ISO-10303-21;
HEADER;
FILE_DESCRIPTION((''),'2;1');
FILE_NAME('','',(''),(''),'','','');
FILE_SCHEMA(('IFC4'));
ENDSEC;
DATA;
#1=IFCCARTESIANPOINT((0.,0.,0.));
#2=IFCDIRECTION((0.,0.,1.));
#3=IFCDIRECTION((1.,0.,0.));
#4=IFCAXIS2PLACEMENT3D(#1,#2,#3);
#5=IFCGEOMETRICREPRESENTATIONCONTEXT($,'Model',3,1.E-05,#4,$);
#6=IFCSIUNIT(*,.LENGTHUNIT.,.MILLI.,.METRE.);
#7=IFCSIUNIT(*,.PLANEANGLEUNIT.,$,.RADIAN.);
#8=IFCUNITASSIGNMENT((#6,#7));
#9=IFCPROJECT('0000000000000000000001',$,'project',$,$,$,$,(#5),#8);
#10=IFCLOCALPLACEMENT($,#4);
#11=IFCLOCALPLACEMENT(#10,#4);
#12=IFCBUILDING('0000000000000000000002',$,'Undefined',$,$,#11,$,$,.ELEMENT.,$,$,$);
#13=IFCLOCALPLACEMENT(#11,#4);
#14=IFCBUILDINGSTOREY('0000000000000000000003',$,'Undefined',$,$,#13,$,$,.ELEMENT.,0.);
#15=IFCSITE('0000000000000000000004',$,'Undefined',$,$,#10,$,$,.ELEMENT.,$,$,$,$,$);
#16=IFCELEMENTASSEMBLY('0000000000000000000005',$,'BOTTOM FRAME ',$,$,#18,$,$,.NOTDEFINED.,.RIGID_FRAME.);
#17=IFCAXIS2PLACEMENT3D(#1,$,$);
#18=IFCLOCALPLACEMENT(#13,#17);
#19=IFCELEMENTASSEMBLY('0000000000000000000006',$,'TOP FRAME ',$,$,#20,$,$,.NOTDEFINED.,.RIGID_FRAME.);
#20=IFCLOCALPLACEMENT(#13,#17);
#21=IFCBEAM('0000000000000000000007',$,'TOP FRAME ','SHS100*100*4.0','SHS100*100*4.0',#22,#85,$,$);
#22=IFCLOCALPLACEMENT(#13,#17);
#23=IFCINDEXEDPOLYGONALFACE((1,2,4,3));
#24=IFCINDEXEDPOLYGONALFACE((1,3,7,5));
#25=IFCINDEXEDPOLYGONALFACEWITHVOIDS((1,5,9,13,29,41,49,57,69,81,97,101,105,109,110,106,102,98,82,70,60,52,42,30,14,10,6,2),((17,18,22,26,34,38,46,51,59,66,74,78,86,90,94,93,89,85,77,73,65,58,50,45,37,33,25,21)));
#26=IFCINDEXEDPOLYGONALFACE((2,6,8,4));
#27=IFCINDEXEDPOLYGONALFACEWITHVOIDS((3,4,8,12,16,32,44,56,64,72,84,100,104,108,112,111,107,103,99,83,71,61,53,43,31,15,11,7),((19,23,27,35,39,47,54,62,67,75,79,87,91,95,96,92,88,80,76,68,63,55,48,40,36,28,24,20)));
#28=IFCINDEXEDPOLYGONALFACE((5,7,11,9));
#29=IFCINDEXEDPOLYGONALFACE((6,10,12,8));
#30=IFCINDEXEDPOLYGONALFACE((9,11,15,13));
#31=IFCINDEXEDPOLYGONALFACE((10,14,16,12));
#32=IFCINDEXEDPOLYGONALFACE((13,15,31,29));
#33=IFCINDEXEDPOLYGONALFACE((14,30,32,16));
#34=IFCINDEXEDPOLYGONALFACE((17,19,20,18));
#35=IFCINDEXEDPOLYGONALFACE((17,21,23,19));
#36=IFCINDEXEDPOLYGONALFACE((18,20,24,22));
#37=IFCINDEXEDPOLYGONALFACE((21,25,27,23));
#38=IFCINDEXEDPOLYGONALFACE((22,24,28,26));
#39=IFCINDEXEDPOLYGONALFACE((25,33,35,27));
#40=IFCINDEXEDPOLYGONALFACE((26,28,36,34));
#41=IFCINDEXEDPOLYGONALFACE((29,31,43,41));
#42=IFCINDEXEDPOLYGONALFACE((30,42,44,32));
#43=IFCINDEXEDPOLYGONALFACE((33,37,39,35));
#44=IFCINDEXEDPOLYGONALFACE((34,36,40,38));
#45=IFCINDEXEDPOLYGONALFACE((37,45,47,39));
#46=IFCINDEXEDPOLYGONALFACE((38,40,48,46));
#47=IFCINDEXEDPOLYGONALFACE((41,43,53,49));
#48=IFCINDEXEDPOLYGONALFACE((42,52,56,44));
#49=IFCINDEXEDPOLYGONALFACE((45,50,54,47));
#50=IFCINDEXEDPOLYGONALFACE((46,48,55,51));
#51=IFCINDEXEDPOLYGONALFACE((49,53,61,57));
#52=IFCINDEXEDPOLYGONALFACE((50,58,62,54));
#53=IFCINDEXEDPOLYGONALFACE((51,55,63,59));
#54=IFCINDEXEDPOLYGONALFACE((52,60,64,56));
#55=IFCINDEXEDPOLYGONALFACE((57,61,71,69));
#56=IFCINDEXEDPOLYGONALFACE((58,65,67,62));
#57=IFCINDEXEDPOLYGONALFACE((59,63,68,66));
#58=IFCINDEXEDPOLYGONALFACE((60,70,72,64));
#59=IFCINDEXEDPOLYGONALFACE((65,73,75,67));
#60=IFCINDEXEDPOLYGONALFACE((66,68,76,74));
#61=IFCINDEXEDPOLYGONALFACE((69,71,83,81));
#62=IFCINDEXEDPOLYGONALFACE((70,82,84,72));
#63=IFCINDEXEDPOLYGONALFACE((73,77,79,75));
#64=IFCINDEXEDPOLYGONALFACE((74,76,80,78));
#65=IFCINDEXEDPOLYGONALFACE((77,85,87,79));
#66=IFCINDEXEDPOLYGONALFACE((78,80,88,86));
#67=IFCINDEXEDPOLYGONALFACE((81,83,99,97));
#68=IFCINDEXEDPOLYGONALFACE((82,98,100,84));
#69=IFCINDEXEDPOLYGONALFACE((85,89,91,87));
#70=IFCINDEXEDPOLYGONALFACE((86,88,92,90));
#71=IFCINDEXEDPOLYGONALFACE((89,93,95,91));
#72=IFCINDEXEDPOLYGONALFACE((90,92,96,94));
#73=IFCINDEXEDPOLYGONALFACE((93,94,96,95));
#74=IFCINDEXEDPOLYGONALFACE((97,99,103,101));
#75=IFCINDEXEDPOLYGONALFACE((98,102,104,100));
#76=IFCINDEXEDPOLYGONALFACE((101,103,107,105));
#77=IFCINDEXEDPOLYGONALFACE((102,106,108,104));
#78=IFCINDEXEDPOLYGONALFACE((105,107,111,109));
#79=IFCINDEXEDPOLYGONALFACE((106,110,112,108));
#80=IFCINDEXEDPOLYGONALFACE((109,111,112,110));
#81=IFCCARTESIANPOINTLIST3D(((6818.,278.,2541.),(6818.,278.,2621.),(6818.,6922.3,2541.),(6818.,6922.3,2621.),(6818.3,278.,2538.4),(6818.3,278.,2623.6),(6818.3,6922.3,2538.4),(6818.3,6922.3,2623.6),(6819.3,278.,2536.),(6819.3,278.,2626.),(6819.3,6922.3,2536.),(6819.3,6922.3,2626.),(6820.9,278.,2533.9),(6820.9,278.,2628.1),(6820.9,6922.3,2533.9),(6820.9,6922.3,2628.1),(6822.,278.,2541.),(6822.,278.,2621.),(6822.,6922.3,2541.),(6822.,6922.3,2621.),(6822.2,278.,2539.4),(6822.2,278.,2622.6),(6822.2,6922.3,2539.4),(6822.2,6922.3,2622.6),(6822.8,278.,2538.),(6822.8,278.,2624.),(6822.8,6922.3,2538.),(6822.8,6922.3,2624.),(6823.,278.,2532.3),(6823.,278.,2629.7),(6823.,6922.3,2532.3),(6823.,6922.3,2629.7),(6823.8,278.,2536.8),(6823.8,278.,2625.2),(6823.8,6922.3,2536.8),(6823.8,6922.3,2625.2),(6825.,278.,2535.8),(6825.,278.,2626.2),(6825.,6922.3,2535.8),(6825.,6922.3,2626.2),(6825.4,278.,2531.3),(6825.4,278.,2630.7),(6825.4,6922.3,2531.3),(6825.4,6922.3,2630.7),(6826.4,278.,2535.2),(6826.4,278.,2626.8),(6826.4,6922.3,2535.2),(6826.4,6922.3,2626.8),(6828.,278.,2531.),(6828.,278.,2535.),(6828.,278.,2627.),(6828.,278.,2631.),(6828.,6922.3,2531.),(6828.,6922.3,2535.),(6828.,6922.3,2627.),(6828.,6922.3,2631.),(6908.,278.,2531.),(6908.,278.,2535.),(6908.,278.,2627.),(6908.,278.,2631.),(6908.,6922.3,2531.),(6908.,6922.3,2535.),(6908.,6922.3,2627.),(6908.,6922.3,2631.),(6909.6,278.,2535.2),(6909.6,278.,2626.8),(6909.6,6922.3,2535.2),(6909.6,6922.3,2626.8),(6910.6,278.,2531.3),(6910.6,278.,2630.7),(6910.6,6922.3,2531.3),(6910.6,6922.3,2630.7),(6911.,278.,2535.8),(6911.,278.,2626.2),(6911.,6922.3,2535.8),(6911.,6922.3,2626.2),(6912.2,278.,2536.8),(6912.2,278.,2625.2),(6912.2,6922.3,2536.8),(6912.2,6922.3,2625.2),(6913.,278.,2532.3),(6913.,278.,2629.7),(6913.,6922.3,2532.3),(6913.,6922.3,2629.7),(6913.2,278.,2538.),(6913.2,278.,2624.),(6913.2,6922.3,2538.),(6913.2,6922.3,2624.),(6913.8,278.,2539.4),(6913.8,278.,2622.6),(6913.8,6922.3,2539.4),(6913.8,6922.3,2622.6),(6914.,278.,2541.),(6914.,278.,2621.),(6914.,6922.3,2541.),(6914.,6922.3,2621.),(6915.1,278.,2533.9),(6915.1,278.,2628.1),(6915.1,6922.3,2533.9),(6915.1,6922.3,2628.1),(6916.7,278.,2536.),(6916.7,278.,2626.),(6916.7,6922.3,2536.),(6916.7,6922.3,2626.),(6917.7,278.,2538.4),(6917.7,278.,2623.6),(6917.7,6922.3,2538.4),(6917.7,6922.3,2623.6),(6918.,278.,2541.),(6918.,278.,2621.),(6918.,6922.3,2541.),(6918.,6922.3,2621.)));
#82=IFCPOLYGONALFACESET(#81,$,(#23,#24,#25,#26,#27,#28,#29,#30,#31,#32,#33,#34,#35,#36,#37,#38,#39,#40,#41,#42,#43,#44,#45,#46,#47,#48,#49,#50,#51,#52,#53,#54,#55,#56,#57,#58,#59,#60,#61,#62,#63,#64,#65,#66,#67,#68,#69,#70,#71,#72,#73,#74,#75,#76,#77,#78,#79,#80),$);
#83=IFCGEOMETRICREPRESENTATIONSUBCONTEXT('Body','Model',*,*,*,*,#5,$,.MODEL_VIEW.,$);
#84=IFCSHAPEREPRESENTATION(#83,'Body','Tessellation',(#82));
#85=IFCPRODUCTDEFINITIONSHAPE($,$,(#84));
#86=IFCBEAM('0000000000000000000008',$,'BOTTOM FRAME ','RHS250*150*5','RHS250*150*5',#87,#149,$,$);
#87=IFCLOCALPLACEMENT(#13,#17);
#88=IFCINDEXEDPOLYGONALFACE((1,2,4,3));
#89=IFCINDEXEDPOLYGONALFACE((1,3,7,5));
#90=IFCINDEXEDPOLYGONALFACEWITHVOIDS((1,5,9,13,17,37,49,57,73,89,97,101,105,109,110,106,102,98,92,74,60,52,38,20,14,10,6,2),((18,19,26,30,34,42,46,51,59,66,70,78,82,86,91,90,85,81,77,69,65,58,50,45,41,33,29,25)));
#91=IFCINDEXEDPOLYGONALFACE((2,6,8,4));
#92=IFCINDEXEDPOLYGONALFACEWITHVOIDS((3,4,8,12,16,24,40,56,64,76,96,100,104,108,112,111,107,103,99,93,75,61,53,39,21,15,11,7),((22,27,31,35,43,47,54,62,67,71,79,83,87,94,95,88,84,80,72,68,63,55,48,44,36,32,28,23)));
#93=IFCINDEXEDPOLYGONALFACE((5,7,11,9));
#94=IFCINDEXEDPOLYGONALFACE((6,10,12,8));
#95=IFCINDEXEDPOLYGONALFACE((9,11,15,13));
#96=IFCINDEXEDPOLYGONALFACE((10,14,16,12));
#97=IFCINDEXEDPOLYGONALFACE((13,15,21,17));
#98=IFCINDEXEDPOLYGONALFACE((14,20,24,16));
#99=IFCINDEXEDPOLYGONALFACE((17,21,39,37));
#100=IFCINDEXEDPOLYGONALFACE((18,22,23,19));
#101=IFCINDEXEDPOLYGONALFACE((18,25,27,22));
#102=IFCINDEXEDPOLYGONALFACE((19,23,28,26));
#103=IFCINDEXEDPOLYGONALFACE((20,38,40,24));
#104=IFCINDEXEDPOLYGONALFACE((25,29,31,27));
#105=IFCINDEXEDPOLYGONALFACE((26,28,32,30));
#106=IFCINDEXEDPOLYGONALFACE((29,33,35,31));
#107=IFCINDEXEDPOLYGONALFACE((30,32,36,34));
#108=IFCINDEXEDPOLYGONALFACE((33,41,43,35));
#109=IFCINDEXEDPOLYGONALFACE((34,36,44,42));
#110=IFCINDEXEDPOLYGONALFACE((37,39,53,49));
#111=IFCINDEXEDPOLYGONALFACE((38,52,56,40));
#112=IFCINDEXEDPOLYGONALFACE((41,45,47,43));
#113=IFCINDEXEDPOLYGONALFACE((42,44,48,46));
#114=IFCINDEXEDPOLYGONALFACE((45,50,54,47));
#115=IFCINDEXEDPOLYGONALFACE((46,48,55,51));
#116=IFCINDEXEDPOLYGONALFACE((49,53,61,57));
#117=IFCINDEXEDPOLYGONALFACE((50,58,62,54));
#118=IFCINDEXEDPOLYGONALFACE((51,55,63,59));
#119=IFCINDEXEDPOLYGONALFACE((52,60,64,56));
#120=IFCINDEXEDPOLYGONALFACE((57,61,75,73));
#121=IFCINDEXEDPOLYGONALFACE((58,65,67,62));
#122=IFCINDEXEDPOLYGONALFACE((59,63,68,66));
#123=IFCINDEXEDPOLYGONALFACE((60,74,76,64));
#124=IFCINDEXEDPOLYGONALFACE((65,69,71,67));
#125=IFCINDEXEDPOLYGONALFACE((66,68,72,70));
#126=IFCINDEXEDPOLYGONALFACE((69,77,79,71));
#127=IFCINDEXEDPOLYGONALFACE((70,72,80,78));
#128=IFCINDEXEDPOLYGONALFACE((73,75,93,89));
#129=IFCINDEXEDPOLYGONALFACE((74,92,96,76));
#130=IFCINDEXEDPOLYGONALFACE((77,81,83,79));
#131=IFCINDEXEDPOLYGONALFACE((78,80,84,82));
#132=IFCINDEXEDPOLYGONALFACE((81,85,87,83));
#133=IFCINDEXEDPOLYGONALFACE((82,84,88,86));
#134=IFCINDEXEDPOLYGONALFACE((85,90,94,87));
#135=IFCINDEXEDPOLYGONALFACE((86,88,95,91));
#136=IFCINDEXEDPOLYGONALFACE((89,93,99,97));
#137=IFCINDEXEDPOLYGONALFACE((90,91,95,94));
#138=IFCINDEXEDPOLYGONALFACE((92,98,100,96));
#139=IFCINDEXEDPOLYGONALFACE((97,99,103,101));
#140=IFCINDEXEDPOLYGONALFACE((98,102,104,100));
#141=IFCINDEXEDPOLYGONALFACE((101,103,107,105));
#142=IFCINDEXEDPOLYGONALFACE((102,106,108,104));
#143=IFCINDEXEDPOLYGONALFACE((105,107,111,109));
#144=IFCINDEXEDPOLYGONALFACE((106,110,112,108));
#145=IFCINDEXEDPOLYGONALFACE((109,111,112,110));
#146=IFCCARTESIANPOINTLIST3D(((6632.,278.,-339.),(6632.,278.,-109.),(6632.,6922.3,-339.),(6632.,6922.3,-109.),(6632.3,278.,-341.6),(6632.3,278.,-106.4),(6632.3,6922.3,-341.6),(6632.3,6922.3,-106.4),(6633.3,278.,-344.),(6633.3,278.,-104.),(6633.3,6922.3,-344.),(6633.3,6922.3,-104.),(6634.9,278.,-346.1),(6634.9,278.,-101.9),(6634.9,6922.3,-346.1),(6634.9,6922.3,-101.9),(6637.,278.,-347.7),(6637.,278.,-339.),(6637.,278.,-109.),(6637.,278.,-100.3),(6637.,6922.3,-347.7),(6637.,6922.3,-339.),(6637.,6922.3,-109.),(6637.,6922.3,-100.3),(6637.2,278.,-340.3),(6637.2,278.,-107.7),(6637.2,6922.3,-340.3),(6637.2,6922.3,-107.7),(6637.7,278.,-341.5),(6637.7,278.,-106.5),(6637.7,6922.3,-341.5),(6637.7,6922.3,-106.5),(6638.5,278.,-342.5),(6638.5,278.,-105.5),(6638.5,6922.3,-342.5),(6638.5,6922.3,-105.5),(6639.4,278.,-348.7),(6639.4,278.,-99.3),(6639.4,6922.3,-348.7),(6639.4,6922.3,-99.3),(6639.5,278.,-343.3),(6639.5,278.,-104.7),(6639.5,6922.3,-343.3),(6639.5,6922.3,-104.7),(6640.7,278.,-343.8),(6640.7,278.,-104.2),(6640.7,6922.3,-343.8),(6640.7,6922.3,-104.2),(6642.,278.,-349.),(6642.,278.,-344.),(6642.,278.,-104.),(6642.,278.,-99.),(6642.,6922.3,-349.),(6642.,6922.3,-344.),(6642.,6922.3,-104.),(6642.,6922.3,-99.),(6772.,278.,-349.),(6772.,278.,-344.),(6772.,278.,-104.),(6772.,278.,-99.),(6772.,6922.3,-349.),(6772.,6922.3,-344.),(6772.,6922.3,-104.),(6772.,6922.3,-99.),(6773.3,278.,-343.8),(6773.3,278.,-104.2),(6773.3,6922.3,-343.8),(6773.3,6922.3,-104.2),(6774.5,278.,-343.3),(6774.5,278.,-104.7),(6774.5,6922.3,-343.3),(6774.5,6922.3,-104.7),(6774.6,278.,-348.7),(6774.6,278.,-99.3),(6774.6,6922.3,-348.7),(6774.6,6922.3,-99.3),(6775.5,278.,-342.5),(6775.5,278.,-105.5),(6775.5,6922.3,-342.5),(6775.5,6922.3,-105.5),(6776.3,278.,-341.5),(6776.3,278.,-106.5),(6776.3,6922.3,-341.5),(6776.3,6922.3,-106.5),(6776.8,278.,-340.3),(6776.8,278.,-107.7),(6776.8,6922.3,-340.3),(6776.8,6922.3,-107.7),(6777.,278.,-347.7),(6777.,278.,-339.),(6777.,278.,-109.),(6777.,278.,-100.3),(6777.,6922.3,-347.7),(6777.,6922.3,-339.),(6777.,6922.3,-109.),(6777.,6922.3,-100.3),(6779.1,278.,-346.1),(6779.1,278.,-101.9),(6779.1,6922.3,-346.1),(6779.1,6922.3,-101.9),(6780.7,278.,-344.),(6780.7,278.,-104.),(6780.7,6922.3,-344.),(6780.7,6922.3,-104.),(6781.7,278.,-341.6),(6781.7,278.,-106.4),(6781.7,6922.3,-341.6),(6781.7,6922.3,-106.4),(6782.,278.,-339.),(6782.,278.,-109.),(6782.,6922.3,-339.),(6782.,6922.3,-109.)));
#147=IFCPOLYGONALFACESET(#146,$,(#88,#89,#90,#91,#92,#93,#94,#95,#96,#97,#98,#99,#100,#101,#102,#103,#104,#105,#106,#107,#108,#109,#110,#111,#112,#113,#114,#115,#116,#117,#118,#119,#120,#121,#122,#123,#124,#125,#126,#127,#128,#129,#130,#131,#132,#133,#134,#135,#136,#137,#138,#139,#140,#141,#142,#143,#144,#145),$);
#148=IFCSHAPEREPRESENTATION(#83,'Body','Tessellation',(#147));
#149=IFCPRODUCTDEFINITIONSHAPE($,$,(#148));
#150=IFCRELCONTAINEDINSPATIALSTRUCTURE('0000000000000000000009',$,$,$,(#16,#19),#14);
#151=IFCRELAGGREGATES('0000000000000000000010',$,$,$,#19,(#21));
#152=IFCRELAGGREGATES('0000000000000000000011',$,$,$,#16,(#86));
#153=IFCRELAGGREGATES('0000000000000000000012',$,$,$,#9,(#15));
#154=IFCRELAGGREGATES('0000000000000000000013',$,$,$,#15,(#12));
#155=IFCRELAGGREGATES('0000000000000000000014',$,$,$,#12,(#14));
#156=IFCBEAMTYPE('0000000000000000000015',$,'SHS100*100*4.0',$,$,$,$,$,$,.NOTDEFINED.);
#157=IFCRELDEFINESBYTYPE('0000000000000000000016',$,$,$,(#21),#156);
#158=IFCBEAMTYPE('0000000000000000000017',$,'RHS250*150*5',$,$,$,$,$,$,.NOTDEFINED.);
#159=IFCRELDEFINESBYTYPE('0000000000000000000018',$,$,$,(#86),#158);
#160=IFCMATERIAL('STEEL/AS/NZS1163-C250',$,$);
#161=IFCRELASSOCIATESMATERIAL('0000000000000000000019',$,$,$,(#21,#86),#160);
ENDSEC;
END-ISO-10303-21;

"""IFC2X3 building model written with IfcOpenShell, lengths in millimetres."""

from ifc_helpers import new_model, si_unit, frame, origin_with_axes, origin_2d_with_axis, place, context, subcontext, project, spatial, hollow_rectangle, extrude, material, type_object, element, aggregate, save


model = new_model("IFC2X3")

# Units and contexts
model_context = context("Model", 3, precision=1e-05, world=origin_with_axes())
body_context = subcontext(model_context, "Body", "Model", "MODEL_VIEW")
ifc_project = project(units=[si_unit("LENGTHUNIT", "METRE", prefix="MILLI"), si_unit("PLANEANGLEUNIT", "RADIAN")], contexts=[model_context])

# Site, building, storey
site_placement = place(None, origin_with_axes())
site = spatial("IfcSite", under=ifc_project, at=site_placement, Name="Undefined", CompositionType="ELEMENT")
building_placement = place(site_placement, origin_with_axes())
building = spatial("IfcBuilding", under=site, at=building_placement, Name="Undefined", CompositionType="ELEMENT")
storey_placement = place(building_placement, origin_with_axes())
storey = spatial("IfcBuildingStorey", under=building, at=storey_placement, Name="Undefined", CompositionType="ELEMENT", Elevation=0.0)

# Element assemblies
assembly_1_placement = place(storey_placement, origin_with_axes())
assembly_1 = element("IfcElementAssembly", 1, at=assembly_1_placement, inside=storey, Name="BOTTOM FRAME ", AssemblyPlace="NOTDEFINED", PredefinedType="RIGID_FRAME")
ifc_material_1 = material(Name="STEEL/AS/NZS1163-C250")
assembly_2_placement = place(storey_placement, origin_with_axes())
assembly_2 = element("IfcElementAssembly", 2, at=assembly_2_placement, inside=storey, Name="TOP FRAME ", AssemblyPlace="NOTDEFINED", PredefinedType="RIGID_FRAME")

# Beams
beam_type_1 = type_object("IfcBeamType", Name="SHS100*100*4.0", PredefinedType="NOTDEFINED")
beam_1_placement = place(assembly_2_placement, frame((6868.0, 6922.3, 2581.0), z_axis=(0.0, 0.0, 1.0), x_axis=(0.0, -1.0, 0.0)))
beam_1 = element("IfcBeam", 3, at=beam_1_placement, type_object=beam_type_1, material=ifc_material_1, Name="TOP FRAME ", Description="SHS100*100*4.0", ObjectType="SHS100*100*4.0", context=body_context, shape_type="SweptSolid", body=[
    extrude(hollow_rectangle(XDim=100.0, YDim=100.0, WallThickness=4.0, InnerFilletRadius=6.0, OuterFilletRadius=10.0, at=origin_2d_with_axis()), frame((6644.3, 0.0, 0.0), z_axis=(-1.0, 0.0, 0.0), x_axis=(0.0, -1.0, 0.0)), (0.0, 0.0, 1.0), 6644.3),
])
aggregate(assembly_2, [beam_1])
beam_type_2 = type_object("IfcBeamType", Name="RHS250*150*5", PredefinedType="NOTDEFINED")
beam_2_placement = place(assembly_1_placement, frame((6707.0, 6922.3, -224.0), z_axis=(0.0, 0.0, 1.0), x_axis=(0.0, -1.0, 0.0)))
beam_2 = element("IfcBeam", 4, at=beam_2_placement, type_object=beam_type_2, material=ifc_material_1, Name="BOTTOM FRAME ", Description="RHS250*150*5", ObjectType="RHS250*150*5", context=body_context, shape_type="SweptSolid", body=[
    extrude(hollow_rectangle(XDim=150.0, YDim=250.0, WallThickness=5.0, InnerFilletRadius=5.0, OuterFilletRadius=10.0, at=origin_2d_with_axis()), frame((6644.3, 0.0, 0.0), z_axis=(-1.0, 0.0, 0.0), x_axis=(0.0, -1.0, 0.0)), (0.0, 0.0, 1.0), 6644.3),
])
aggregate(assembly_1, [beam_2])

save(model, "model.ifc")
